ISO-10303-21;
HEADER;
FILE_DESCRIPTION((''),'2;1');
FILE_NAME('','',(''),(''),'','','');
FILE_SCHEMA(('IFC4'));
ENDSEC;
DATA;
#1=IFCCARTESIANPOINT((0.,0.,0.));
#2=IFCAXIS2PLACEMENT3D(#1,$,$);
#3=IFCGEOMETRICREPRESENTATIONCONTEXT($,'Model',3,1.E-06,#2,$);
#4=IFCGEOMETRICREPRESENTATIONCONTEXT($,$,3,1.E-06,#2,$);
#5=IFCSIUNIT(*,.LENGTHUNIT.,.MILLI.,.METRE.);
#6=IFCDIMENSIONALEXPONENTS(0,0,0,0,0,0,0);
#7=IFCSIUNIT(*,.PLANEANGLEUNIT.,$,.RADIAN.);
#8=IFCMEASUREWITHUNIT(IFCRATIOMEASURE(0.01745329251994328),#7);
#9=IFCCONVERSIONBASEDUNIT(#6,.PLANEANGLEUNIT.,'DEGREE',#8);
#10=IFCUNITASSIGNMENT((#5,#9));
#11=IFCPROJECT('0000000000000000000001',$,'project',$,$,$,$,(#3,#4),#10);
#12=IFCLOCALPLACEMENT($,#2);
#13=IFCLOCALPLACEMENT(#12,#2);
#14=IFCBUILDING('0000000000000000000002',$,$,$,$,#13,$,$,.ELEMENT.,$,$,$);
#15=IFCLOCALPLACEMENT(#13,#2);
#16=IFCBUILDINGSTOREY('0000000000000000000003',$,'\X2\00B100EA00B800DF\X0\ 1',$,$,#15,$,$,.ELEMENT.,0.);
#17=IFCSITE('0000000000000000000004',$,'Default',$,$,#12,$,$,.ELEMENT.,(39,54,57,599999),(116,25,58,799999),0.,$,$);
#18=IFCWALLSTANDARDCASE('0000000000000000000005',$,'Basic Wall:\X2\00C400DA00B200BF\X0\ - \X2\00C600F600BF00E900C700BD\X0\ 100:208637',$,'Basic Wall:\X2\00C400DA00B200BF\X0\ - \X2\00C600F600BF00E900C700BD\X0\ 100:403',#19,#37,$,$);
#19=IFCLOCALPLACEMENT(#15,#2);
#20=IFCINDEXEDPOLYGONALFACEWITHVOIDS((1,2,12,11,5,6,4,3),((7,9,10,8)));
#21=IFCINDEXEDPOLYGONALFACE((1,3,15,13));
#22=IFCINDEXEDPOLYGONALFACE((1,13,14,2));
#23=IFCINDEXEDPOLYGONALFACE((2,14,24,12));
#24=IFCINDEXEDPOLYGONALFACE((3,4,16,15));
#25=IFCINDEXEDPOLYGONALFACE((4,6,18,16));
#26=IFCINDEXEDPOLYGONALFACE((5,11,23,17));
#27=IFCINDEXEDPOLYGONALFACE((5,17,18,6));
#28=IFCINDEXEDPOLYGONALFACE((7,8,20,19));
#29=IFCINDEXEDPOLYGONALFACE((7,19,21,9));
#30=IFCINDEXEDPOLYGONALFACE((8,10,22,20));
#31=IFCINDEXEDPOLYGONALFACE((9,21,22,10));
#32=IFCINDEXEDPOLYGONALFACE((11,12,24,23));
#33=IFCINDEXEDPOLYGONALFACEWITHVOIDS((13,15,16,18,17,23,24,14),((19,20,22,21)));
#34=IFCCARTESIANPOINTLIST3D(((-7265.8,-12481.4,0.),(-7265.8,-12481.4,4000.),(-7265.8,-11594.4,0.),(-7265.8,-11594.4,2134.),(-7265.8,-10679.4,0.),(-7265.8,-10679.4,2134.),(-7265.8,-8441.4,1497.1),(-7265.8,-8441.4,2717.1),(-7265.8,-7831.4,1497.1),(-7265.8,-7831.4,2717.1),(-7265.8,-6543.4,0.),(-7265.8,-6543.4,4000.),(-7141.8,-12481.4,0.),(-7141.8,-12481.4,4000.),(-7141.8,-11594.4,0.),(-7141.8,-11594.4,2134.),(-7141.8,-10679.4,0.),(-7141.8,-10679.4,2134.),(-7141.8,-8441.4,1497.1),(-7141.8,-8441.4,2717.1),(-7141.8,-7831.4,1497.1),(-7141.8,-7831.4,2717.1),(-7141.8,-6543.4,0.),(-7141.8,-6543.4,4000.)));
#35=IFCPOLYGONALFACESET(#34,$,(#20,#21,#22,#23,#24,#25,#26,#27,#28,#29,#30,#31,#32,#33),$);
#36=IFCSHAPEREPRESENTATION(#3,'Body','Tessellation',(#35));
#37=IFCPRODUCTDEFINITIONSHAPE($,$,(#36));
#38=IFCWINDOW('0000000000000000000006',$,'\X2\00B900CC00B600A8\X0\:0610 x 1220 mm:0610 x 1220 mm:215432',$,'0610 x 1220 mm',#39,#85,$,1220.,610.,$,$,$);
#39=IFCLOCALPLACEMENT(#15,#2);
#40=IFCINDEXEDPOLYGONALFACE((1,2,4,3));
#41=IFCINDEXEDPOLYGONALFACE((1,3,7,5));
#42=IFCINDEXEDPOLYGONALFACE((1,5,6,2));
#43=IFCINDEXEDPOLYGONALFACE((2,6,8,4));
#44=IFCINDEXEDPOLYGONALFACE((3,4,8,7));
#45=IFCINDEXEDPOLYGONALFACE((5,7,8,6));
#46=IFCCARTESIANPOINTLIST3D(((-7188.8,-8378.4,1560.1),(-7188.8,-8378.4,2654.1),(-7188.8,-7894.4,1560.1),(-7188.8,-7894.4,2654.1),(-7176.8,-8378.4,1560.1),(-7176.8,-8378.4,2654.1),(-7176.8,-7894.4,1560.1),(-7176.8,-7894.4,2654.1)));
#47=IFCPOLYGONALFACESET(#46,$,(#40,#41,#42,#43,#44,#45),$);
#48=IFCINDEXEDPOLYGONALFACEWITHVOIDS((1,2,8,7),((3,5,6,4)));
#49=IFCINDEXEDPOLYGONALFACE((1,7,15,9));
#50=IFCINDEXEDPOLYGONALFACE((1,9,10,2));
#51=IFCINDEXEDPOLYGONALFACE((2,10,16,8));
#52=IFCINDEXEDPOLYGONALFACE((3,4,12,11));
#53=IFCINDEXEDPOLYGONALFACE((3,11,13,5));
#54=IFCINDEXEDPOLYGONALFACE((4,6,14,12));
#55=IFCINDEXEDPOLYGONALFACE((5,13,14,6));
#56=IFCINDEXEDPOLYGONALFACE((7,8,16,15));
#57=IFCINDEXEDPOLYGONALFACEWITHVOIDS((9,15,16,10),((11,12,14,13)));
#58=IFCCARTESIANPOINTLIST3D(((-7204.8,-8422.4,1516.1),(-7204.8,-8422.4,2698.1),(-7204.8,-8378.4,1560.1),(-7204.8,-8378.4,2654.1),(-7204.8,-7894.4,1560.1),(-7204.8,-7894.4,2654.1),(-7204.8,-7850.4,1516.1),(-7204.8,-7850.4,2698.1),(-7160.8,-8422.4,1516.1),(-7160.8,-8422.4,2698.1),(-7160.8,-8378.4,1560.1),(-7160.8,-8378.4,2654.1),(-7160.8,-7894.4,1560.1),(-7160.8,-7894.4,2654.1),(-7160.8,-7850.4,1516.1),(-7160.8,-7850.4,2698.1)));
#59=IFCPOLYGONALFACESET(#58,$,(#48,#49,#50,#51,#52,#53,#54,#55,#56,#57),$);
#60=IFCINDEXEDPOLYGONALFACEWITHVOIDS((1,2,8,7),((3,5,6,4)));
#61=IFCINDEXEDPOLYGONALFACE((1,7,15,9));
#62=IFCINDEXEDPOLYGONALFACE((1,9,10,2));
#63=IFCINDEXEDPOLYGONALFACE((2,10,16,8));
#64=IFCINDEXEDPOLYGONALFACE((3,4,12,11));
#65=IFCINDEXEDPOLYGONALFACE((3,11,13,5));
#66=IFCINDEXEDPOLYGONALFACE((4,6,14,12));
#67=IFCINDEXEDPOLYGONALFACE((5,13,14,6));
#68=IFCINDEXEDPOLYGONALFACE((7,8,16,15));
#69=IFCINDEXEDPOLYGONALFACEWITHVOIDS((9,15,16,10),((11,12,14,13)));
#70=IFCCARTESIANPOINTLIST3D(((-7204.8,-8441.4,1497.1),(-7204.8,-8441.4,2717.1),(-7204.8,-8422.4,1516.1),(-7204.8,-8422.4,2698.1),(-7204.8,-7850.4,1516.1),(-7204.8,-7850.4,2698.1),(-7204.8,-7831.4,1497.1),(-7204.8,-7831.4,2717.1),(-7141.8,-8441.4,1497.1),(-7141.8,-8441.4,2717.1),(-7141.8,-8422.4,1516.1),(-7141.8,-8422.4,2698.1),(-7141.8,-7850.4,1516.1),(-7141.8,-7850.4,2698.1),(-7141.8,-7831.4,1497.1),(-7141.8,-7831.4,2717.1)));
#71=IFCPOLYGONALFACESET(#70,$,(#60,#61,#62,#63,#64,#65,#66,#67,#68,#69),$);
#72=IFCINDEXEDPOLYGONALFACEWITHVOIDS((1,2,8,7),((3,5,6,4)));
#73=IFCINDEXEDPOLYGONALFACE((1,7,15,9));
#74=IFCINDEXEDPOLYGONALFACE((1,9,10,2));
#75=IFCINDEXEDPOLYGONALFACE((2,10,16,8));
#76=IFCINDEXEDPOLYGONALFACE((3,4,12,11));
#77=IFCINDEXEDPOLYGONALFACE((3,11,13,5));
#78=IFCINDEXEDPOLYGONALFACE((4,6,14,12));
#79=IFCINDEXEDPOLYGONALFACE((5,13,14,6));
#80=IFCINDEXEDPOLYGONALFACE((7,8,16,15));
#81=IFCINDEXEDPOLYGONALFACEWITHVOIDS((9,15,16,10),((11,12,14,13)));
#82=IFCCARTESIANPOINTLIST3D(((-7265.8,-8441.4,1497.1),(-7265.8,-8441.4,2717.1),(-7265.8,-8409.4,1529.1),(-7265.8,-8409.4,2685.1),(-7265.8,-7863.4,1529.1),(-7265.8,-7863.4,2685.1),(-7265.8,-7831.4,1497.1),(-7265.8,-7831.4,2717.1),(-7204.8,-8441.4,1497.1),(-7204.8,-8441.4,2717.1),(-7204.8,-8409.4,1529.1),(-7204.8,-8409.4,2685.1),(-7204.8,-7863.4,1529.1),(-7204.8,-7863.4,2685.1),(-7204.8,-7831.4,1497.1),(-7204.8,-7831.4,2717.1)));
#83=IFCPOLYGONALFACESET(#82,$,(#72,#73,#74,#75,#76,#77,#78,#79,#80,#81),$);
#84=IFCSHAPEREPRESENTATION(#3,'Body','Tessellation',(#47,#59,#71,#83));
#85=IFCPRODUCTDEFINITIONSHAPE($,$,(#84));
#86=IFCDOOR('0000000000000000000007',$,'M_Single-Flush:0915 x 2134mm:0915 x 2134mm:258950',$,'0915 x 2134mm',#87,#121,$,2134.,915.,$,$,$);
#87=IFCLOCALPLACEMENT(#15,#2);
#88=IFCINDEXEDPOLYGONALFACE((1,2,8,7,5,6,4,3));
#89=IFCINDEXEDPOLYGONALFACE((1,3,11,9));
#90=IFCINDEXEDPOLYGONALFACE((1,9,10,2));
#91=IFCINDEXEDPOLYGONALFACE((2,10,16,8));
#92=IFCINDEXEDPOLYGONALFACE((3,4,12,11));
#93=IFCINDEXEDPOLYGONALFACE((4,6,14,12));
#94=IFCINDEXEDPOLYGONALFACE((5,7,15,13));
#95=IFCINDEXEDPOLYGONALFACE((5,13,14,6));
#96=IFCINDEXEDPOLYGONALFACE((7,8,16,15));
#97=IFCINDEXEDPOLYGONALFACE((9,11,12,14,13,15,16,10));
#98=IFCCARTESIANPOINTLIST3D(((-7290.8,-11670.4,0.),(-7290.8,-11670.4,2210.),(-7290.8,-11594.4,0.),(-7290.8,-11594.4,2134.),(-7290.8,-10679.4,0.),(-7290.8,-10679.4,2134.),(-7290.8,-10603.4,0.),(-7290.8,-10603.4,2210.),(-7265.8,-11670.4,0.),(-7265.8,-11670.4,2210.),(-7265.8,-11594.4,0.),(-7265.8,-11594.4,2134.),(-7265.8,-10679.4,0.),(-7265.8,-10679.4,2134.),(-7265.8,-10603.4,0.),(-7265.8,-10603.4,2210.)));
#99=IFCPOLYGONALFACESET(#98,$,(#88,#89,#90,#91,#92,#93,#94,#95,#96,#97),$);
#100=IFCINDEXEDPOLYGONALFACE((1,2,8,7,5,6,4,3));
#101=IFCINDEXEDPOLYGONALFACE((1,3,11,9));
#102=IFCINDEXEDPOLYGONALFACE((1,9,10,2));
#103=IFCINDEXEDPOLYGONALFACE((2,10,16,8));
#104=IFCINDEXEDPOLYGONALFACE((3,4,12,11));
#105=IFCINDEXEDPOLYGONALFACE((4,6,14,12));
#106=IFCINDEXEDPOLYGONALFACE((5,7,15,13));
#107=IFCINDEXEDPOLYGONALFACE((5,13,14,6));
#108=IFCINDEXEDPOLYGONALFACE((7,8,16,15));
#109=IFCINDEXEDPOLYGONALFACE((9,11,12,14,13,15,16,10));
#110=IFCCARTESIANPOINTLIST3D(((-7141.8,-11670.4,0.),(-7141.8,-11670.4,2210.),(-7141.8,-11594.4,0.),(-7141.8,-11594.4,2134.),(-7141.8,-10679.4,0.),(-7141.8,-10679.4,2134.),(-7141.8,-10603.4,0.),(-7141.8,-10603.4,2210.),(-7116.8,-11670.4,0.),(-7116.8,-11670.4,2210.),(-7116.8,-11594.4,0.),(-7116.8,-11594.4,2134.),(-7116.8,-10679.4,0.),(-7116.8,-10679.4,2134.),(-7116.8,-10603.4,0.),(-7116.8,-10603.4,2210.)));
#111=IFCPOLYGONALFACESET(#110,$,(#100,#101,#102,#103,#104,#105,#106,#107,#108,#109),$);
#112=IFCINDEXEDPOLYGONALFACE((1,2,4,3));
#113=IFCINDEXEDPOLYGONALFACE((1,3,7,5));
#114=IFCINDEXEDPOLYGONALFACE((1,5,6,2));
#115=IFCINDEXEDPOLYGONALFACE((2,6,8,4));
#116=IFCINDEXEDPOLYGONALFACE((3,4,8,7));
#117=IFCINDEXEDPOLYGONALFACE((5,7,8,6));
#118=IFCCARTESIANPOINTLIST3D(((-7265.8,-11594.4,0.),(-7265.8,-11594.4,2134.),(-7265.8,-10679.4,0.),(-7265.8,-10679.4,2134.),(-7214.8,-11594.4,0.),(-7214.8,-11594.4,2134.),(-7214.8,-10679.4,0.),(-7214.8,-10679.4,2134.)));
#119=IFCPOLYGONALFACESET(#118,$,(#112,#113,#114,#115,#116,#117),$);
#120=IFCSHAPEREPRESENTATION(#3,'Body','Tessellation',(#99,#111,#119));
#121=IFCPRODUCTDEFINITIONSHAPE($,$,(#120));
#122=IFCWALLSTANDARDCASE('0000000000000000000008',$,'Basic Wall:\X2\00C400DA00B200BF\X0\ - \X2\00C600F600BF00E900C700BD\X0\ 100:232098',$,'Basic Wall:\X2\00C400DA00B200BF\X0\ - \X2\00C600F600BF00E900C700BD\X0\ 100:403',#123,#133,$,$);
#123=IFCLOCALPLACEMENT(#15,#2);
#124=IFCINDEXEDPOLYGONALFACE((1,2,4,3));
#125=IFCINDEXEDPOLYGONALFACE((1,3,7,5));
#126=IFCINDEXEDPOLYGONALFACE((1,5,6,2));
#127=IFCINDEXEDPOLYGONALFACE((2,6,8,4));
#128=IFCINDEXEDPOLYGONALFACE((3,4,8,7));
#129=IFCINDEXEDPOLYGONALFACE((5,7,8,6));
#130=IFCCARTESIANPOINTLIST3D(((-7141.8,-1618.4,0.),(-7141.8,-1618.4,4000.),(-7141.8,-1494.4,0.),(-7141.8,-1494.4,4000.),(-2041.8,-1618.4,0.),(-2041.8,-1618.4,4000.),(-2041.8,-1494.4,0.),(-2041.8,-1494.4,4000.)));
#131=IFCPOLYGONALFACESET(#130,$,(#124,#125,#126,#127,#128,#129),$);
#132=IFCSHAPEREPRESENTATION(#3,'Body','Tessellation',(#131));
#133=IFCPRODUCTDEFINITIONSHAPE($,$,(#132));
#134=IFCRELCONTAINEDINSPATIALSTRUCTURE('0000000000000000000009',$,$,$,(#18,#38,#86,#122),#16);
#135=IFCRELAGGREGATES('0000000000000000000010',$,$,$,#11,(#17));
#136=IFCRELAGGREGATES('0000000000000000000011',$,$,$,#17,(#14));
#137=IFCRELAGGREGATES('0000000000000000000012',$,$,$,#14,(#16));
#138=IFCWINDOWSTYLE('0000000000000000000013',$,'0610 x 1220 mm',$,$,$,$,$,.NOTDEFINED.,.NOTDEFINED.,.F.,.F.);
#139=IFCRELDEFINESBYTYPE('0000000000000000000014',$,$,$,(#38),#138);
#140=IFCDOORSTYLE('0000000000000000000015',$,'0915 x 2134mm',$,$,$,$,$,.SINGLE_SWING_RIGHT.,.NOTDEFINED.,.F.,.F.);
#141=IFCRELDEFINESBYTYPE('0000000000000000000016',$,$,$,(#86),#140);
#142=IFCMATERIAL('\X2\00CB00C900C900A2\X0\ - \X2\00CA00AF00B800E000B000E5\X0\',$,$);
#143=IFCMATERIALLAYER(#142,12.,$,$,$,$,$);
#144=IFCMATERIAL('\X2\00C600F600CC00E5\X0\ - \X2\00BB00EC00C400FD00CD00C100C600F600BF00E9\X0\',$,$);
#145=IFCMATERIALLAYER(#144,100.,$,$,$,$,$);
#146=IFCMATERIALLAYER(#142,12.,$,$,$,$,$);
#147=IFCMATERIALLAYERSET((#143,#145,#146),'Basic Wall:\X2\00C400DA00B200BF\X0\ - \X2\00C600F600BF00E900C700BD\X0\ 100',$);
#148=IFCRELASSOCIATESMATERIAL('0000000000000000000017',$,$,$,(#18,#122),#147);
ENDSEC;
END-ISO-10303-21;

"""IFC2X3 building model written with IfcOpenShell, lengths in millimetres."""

from ifc_helpers import new_model, entity, si_unit, converted_unit, frame, frame_2d, origin, origin_2d_with_axis, place, context, project, spatial, polyline, rectangle, outline, extrude, source, transform, mapped, material, layer, layer_set, layer_usage, type_object, type_shapes, element, fill, save


model = new_model("IFC2X3")

# Units and contexts
model_context = context("Model", 3, precision=1e-06, world=origin())
context_of_model = context(None, 3, precision=1e-06, world=origin())
ifc_project = project(units=[si_unit("LENGTHUNIT", "METRE", prefix="MILLI"), converted_unit("PLANEANGLEUNIT", "DEGREE", entity("IfcRatioMeasure", 0.01745329251994328), si_unit("PLANEANGLEUNIT", "RADIAN"), dimensions=[0, 0, 0, 0, 0, 0, 0])], contexts=[model_context, context_of_model])

# Site, building, storey
site_placement = place(None, origin())
site = spatial("IfcSite", under=ifc_project, at=site_placement, Name="Default", CompositionType="ELEMENT", RefLatitude=(39, 54, 57, 599999), RefLongitude=(116, 25, 58, 799999), RefElevation=0.0)
building_placement = place(site_placement, origin())
building = spatial("IfcBuilding", under=site, at=building_placement, CompositionType="ELEMENT")
storey_placement = place(building_placement, origin())
storey = spatial("IfcBuildingStorey", under=building, at=storey_placement, Name="±ê¸ß 1", CompositionType="ELEMENT", Elevation=0.0)

# Shared definitions
ifc_material_1 = material(Name="ËÉÉ¢ - Ê¯¸à°å")

# Shared definitions
ifc_layer_1 = layer(ifc_material_1, 12.0)
ifc_material_2 = material(Name="ÆöÌå - »ìÄýÍÁÆö¿é")
ifc_layer_2 = layer(ifc_material_2, 100.0)
ifc_layer_3 = layer(ifc_material_1, 12.0)
ifc_layer_set_1 = layer_set([ifc_layer_1, ifc_layer_2, ifc_layer_3], Name="Basic Wall:ÄÚ²¿ - Æö¿éÇ½ 100")

# Wall, openings, window, door
ifc_layer_usage_1 = layer_usage(ifc_layer_set_1, "AXIS2", "NEGATIVE", 62.0)
wall_1_placement = place(storey_placement, frame((-7203.8, -6543.4, 0.0), z_axis=(0.0, 0.0, 1.0), x_axis=(0.0, -1.0, 0.0)))
wall_1 = element("IfcWallStandardCase", 1, at=wall_1_placement, inside=storey, material=ifc_layer_usage_1, Name="Basic Wall:ÄÚ²¿ - Æö¿éÇ½ 100:208637", ObjectType="Basic Wall:ÄÚ²¿ - Æö¿éÇ½ 100:403", context=model_context, shape_type="SweptSolid", body=[
    extrude(rectangle(XDim=5938.0, YDim=124.0, at=frame_2d((2969.0, 0.0), x_axis=(-1.0, 0.0))), origin(), (0.0, 0.0, 1.0), 4000.0),
])
opening_1_placement = place(wall_1_placement, frame((1288.0, -62.0, 1497.1)))
opening_1 = element("IfcOpeningElement", 2, at=opening_1_placement, cuts=wall_1, ObjectType="Opening", context=model_context, shape_type="SweptSolid", body=[
    extrude(rectangle(XDim=1220.0, YDim=610.0, at=frame_2d((610.0, 305.0), x_axis=(1.0, 0.0))), frame((0.0, 0.0, 0.0), z_axis=(0.0, 1.0, 0.0), x_axis=(0.0, 0.0, 1.0)), (0.0, 0.0, 1.0), 124.0),
])
opening_2_placement = place(wall_1_placement, frame((5051.0, 62.0, 0.0)))
opening_2 = element("IfcOpeningElement", 3, at=opening_2_placement, cuts=wall_1, ObjectType="Opening", context=model_context, shape_type="SweptSolid", body=[
    extrude(rectangle(XDim=915.0, YDim=2134.0, at=frame_2d((1067.0, 457.5), x_axis=(0.0, 1.0))), frame((0.0, 0.0, 0.0), z_axis=(0.0, -1.0, 0.0), x_axis=(0.0, 0.0, 1.0)), (0.0, 0.0, 1.0), 124.0),
])
window_style_1 = type_object("IfcWindowStyle", Name="0610 x 1220 mm", ConstructionType="NOTDEFINED", OperationType="NOTDEFINED", ParameterTakesPrecedence=False, Sizeable=False)
shared_shape_1 = source(origin(), model_context, "Body", "SweptSolid", [
    extrude(rectangle(XDim=12.0, YDim=484.0, at=origin_2d_with_axis()), frame((305.0, 83.0, 63.0), z_axis=(0.0, 0.0, 1.0), x_axis=(0.0, -1.0, 0.0)), (0.0, 0.0, 1.0), 1094.0),
    extrude(outline(polyline([(-286.0, -591.0), (286.0, -591.0), (286.0, 591.0), (-286.0, 591.0), (-286.0, -591.0)]), holes=[polyline([(-242.0, -547.0), (-242.0, 547.0), (242.0, 547.0), (242.0, -547.0), (-242.0, -547.0)])]), frame((305.0, 61.0, 610.0), z_axis=(0.0, 1.0, 0.0), x_axis=(1.0, 0.0, 0.0)), (0.0, 0.0, 1.0), 44.0),
    extrude(outline(polyline([(-305.0, -610.0), (305.0, -610.0), (305.0, 610.0), (-305.0, 610.0), (-305.0, -610.0)]), holes=[polyline([(-286.0, -591.0), (-286.0, 591.0), (286.0, 591.0), (286.0, -591.0), (-286.0, -591.0)])]), frame((305.0, 61.0, 610.0), z_axis=(0.0, 1.0, 0.0), x_axis=(1.0, 0.0, 0.0)), (0.0, 0.0, 1.0), 63.0),
    extrude(outline(polyline([(-305.0, -610.0), (305.0, -610.0), (305.0, 610.0), (-305.0, 610.0), (-305.0, -610.0)]), holes=[polyline([(-273.0, -578.0), (-273.0, 578.0), (273.0, 578.0), (273.0, -578.0), (-273.0, -578.0)])]), frame((305.0, 0.0, 610.0), z_axis=(0.0, 1.0, 0.0), x_axis=(1.0, 0.0, 0.0)), (0.0, 0.0, 1.0), 61.0),
])
type_shapes(window_style_1, [shared_shape_1])
window_1_placement = place(opening_1_placement, origin())
window_1 = element("IfcWindow", 4, at=window_1_placement, inside=storey, type_object=window_style_1, Name="¹Ì¶¨:0610 x 1220 mm:0610 x 1220 mm:215432", ObjectType="0610 x 1220 mm", OverallHeight=1220.0, OverallWidth=610.0, context=model_context, shape_type="MappedRepresentation", body=[
    mapped(shared_shape_1, transform((0.0, 0.0, 0.0), scale=1.0)),
])
fill(opening_1, window_1)
door_style = type_object("IfcDoorStyle", Name="0915 x 2134mm", ConstructionType="NOTDEFINED", OperationType="SINGLE_SWING_RIGHT", ParameterTakesPrecedence=False, Sizeable=False)
shared_shape_2 = source(origin(), model_context, "Body", "SweptSolid", [
    extrude(outline(polyline([(-533.5, -1124.0), (533.5, -1124.0), (533.5, 1086.0), (457.5, 1086.0), (457.5, -1048.0), (-457.5, -1048.0), (-457.5, 1086.0), (-533.5, 1086.0), (-533.5, -1124.0)])), frame((457.5, 124.0, 1086.0), z_axis=(0.0, 1.0, 0.0), x_axis=(1.0, 0.0, 0.0)), (0.0, 0.0, 1.0), 25.0),
    extrude(outline(polyline([(-1124.0, -533.5), (1086.0, -533.5), (1086.0, -457.5), (-1048.0, -457.5), (-1048.0, 457.5), (1086.0, 457.5), (1086.0, 533.5), (-1124.0, 533.5), (-1124.0, -533.5)])), frame((457.5, -25.0, 1086.0), z_axis=(0.0, 1.0, 0.0), x_axis=(0.0, 0.0, -1.0)), (0.0, 0.0, 1.0), 25.0),
    extrude(rectangle(XDim=51.0, YDim=915.0, at=origin_2d_with_axis()), frame((457.5, 98.5, 0.0), z_axis=(0.0, 0.0, 1.0), x_axis=(0.0, 1.0, 0.0)), (0.0, 0.0, 1.0), 2134.0),
])
type_shapes(door_style, [shared_shape_2])
door_placement = place(opening_2_placement, frame((0.0, 0.0, 0.0), z_axis=(0.0, 0.0, 1.0), x_axis=(-1.0, 0.0, 0.0)))
door = element("IfcDoor", 5, at=door_placement, inside=storey, type_object=door_style, Name="M_Single-Flush:0915 x 2134mm:0915 x 2134mm:258950", ObjectType="0915 x 2134mm", OverallHeight=2134.0, OverallWidth=915.0, context=model_context, shape_type="MappedRepresentation", body=[
    mapped(shared_shape_2, transform((0.0, 0.0, 0.0), scale=1.0)),
])
fill(opening_2, door)

# Wall
ifc_layer_usage_2 = layer_usage(ifc_layer_set_1, "AXIS2", "NEGATIVE", 62.0)
wall_2_placement = place(storey_placement, frame((-7141.8, -1556.4, 0.0)))
element("IfcWallStandardCase", 6, at=wall_2_placement, inside=storey, material=ifc_layer_usage_2, Name="Basic Wall:ÄÚ²¿ - Æö¿éÇ½ 100:232098", ObjectType="Basic Wall:ÄÚ²¿ - Æö¿éÇ½ 100:403", context=model_context, shape_type="SweptSolid", body=[
    extrude(rectangle(XDim=5100.0, YDim=124.0, at=frame_2d((2550.0, 0.0), x_axis=(-1.0, 0.0))), origin(), (0.0, 0.0, 1.0), 4000.0),
])

save(model, "model.ifc")
